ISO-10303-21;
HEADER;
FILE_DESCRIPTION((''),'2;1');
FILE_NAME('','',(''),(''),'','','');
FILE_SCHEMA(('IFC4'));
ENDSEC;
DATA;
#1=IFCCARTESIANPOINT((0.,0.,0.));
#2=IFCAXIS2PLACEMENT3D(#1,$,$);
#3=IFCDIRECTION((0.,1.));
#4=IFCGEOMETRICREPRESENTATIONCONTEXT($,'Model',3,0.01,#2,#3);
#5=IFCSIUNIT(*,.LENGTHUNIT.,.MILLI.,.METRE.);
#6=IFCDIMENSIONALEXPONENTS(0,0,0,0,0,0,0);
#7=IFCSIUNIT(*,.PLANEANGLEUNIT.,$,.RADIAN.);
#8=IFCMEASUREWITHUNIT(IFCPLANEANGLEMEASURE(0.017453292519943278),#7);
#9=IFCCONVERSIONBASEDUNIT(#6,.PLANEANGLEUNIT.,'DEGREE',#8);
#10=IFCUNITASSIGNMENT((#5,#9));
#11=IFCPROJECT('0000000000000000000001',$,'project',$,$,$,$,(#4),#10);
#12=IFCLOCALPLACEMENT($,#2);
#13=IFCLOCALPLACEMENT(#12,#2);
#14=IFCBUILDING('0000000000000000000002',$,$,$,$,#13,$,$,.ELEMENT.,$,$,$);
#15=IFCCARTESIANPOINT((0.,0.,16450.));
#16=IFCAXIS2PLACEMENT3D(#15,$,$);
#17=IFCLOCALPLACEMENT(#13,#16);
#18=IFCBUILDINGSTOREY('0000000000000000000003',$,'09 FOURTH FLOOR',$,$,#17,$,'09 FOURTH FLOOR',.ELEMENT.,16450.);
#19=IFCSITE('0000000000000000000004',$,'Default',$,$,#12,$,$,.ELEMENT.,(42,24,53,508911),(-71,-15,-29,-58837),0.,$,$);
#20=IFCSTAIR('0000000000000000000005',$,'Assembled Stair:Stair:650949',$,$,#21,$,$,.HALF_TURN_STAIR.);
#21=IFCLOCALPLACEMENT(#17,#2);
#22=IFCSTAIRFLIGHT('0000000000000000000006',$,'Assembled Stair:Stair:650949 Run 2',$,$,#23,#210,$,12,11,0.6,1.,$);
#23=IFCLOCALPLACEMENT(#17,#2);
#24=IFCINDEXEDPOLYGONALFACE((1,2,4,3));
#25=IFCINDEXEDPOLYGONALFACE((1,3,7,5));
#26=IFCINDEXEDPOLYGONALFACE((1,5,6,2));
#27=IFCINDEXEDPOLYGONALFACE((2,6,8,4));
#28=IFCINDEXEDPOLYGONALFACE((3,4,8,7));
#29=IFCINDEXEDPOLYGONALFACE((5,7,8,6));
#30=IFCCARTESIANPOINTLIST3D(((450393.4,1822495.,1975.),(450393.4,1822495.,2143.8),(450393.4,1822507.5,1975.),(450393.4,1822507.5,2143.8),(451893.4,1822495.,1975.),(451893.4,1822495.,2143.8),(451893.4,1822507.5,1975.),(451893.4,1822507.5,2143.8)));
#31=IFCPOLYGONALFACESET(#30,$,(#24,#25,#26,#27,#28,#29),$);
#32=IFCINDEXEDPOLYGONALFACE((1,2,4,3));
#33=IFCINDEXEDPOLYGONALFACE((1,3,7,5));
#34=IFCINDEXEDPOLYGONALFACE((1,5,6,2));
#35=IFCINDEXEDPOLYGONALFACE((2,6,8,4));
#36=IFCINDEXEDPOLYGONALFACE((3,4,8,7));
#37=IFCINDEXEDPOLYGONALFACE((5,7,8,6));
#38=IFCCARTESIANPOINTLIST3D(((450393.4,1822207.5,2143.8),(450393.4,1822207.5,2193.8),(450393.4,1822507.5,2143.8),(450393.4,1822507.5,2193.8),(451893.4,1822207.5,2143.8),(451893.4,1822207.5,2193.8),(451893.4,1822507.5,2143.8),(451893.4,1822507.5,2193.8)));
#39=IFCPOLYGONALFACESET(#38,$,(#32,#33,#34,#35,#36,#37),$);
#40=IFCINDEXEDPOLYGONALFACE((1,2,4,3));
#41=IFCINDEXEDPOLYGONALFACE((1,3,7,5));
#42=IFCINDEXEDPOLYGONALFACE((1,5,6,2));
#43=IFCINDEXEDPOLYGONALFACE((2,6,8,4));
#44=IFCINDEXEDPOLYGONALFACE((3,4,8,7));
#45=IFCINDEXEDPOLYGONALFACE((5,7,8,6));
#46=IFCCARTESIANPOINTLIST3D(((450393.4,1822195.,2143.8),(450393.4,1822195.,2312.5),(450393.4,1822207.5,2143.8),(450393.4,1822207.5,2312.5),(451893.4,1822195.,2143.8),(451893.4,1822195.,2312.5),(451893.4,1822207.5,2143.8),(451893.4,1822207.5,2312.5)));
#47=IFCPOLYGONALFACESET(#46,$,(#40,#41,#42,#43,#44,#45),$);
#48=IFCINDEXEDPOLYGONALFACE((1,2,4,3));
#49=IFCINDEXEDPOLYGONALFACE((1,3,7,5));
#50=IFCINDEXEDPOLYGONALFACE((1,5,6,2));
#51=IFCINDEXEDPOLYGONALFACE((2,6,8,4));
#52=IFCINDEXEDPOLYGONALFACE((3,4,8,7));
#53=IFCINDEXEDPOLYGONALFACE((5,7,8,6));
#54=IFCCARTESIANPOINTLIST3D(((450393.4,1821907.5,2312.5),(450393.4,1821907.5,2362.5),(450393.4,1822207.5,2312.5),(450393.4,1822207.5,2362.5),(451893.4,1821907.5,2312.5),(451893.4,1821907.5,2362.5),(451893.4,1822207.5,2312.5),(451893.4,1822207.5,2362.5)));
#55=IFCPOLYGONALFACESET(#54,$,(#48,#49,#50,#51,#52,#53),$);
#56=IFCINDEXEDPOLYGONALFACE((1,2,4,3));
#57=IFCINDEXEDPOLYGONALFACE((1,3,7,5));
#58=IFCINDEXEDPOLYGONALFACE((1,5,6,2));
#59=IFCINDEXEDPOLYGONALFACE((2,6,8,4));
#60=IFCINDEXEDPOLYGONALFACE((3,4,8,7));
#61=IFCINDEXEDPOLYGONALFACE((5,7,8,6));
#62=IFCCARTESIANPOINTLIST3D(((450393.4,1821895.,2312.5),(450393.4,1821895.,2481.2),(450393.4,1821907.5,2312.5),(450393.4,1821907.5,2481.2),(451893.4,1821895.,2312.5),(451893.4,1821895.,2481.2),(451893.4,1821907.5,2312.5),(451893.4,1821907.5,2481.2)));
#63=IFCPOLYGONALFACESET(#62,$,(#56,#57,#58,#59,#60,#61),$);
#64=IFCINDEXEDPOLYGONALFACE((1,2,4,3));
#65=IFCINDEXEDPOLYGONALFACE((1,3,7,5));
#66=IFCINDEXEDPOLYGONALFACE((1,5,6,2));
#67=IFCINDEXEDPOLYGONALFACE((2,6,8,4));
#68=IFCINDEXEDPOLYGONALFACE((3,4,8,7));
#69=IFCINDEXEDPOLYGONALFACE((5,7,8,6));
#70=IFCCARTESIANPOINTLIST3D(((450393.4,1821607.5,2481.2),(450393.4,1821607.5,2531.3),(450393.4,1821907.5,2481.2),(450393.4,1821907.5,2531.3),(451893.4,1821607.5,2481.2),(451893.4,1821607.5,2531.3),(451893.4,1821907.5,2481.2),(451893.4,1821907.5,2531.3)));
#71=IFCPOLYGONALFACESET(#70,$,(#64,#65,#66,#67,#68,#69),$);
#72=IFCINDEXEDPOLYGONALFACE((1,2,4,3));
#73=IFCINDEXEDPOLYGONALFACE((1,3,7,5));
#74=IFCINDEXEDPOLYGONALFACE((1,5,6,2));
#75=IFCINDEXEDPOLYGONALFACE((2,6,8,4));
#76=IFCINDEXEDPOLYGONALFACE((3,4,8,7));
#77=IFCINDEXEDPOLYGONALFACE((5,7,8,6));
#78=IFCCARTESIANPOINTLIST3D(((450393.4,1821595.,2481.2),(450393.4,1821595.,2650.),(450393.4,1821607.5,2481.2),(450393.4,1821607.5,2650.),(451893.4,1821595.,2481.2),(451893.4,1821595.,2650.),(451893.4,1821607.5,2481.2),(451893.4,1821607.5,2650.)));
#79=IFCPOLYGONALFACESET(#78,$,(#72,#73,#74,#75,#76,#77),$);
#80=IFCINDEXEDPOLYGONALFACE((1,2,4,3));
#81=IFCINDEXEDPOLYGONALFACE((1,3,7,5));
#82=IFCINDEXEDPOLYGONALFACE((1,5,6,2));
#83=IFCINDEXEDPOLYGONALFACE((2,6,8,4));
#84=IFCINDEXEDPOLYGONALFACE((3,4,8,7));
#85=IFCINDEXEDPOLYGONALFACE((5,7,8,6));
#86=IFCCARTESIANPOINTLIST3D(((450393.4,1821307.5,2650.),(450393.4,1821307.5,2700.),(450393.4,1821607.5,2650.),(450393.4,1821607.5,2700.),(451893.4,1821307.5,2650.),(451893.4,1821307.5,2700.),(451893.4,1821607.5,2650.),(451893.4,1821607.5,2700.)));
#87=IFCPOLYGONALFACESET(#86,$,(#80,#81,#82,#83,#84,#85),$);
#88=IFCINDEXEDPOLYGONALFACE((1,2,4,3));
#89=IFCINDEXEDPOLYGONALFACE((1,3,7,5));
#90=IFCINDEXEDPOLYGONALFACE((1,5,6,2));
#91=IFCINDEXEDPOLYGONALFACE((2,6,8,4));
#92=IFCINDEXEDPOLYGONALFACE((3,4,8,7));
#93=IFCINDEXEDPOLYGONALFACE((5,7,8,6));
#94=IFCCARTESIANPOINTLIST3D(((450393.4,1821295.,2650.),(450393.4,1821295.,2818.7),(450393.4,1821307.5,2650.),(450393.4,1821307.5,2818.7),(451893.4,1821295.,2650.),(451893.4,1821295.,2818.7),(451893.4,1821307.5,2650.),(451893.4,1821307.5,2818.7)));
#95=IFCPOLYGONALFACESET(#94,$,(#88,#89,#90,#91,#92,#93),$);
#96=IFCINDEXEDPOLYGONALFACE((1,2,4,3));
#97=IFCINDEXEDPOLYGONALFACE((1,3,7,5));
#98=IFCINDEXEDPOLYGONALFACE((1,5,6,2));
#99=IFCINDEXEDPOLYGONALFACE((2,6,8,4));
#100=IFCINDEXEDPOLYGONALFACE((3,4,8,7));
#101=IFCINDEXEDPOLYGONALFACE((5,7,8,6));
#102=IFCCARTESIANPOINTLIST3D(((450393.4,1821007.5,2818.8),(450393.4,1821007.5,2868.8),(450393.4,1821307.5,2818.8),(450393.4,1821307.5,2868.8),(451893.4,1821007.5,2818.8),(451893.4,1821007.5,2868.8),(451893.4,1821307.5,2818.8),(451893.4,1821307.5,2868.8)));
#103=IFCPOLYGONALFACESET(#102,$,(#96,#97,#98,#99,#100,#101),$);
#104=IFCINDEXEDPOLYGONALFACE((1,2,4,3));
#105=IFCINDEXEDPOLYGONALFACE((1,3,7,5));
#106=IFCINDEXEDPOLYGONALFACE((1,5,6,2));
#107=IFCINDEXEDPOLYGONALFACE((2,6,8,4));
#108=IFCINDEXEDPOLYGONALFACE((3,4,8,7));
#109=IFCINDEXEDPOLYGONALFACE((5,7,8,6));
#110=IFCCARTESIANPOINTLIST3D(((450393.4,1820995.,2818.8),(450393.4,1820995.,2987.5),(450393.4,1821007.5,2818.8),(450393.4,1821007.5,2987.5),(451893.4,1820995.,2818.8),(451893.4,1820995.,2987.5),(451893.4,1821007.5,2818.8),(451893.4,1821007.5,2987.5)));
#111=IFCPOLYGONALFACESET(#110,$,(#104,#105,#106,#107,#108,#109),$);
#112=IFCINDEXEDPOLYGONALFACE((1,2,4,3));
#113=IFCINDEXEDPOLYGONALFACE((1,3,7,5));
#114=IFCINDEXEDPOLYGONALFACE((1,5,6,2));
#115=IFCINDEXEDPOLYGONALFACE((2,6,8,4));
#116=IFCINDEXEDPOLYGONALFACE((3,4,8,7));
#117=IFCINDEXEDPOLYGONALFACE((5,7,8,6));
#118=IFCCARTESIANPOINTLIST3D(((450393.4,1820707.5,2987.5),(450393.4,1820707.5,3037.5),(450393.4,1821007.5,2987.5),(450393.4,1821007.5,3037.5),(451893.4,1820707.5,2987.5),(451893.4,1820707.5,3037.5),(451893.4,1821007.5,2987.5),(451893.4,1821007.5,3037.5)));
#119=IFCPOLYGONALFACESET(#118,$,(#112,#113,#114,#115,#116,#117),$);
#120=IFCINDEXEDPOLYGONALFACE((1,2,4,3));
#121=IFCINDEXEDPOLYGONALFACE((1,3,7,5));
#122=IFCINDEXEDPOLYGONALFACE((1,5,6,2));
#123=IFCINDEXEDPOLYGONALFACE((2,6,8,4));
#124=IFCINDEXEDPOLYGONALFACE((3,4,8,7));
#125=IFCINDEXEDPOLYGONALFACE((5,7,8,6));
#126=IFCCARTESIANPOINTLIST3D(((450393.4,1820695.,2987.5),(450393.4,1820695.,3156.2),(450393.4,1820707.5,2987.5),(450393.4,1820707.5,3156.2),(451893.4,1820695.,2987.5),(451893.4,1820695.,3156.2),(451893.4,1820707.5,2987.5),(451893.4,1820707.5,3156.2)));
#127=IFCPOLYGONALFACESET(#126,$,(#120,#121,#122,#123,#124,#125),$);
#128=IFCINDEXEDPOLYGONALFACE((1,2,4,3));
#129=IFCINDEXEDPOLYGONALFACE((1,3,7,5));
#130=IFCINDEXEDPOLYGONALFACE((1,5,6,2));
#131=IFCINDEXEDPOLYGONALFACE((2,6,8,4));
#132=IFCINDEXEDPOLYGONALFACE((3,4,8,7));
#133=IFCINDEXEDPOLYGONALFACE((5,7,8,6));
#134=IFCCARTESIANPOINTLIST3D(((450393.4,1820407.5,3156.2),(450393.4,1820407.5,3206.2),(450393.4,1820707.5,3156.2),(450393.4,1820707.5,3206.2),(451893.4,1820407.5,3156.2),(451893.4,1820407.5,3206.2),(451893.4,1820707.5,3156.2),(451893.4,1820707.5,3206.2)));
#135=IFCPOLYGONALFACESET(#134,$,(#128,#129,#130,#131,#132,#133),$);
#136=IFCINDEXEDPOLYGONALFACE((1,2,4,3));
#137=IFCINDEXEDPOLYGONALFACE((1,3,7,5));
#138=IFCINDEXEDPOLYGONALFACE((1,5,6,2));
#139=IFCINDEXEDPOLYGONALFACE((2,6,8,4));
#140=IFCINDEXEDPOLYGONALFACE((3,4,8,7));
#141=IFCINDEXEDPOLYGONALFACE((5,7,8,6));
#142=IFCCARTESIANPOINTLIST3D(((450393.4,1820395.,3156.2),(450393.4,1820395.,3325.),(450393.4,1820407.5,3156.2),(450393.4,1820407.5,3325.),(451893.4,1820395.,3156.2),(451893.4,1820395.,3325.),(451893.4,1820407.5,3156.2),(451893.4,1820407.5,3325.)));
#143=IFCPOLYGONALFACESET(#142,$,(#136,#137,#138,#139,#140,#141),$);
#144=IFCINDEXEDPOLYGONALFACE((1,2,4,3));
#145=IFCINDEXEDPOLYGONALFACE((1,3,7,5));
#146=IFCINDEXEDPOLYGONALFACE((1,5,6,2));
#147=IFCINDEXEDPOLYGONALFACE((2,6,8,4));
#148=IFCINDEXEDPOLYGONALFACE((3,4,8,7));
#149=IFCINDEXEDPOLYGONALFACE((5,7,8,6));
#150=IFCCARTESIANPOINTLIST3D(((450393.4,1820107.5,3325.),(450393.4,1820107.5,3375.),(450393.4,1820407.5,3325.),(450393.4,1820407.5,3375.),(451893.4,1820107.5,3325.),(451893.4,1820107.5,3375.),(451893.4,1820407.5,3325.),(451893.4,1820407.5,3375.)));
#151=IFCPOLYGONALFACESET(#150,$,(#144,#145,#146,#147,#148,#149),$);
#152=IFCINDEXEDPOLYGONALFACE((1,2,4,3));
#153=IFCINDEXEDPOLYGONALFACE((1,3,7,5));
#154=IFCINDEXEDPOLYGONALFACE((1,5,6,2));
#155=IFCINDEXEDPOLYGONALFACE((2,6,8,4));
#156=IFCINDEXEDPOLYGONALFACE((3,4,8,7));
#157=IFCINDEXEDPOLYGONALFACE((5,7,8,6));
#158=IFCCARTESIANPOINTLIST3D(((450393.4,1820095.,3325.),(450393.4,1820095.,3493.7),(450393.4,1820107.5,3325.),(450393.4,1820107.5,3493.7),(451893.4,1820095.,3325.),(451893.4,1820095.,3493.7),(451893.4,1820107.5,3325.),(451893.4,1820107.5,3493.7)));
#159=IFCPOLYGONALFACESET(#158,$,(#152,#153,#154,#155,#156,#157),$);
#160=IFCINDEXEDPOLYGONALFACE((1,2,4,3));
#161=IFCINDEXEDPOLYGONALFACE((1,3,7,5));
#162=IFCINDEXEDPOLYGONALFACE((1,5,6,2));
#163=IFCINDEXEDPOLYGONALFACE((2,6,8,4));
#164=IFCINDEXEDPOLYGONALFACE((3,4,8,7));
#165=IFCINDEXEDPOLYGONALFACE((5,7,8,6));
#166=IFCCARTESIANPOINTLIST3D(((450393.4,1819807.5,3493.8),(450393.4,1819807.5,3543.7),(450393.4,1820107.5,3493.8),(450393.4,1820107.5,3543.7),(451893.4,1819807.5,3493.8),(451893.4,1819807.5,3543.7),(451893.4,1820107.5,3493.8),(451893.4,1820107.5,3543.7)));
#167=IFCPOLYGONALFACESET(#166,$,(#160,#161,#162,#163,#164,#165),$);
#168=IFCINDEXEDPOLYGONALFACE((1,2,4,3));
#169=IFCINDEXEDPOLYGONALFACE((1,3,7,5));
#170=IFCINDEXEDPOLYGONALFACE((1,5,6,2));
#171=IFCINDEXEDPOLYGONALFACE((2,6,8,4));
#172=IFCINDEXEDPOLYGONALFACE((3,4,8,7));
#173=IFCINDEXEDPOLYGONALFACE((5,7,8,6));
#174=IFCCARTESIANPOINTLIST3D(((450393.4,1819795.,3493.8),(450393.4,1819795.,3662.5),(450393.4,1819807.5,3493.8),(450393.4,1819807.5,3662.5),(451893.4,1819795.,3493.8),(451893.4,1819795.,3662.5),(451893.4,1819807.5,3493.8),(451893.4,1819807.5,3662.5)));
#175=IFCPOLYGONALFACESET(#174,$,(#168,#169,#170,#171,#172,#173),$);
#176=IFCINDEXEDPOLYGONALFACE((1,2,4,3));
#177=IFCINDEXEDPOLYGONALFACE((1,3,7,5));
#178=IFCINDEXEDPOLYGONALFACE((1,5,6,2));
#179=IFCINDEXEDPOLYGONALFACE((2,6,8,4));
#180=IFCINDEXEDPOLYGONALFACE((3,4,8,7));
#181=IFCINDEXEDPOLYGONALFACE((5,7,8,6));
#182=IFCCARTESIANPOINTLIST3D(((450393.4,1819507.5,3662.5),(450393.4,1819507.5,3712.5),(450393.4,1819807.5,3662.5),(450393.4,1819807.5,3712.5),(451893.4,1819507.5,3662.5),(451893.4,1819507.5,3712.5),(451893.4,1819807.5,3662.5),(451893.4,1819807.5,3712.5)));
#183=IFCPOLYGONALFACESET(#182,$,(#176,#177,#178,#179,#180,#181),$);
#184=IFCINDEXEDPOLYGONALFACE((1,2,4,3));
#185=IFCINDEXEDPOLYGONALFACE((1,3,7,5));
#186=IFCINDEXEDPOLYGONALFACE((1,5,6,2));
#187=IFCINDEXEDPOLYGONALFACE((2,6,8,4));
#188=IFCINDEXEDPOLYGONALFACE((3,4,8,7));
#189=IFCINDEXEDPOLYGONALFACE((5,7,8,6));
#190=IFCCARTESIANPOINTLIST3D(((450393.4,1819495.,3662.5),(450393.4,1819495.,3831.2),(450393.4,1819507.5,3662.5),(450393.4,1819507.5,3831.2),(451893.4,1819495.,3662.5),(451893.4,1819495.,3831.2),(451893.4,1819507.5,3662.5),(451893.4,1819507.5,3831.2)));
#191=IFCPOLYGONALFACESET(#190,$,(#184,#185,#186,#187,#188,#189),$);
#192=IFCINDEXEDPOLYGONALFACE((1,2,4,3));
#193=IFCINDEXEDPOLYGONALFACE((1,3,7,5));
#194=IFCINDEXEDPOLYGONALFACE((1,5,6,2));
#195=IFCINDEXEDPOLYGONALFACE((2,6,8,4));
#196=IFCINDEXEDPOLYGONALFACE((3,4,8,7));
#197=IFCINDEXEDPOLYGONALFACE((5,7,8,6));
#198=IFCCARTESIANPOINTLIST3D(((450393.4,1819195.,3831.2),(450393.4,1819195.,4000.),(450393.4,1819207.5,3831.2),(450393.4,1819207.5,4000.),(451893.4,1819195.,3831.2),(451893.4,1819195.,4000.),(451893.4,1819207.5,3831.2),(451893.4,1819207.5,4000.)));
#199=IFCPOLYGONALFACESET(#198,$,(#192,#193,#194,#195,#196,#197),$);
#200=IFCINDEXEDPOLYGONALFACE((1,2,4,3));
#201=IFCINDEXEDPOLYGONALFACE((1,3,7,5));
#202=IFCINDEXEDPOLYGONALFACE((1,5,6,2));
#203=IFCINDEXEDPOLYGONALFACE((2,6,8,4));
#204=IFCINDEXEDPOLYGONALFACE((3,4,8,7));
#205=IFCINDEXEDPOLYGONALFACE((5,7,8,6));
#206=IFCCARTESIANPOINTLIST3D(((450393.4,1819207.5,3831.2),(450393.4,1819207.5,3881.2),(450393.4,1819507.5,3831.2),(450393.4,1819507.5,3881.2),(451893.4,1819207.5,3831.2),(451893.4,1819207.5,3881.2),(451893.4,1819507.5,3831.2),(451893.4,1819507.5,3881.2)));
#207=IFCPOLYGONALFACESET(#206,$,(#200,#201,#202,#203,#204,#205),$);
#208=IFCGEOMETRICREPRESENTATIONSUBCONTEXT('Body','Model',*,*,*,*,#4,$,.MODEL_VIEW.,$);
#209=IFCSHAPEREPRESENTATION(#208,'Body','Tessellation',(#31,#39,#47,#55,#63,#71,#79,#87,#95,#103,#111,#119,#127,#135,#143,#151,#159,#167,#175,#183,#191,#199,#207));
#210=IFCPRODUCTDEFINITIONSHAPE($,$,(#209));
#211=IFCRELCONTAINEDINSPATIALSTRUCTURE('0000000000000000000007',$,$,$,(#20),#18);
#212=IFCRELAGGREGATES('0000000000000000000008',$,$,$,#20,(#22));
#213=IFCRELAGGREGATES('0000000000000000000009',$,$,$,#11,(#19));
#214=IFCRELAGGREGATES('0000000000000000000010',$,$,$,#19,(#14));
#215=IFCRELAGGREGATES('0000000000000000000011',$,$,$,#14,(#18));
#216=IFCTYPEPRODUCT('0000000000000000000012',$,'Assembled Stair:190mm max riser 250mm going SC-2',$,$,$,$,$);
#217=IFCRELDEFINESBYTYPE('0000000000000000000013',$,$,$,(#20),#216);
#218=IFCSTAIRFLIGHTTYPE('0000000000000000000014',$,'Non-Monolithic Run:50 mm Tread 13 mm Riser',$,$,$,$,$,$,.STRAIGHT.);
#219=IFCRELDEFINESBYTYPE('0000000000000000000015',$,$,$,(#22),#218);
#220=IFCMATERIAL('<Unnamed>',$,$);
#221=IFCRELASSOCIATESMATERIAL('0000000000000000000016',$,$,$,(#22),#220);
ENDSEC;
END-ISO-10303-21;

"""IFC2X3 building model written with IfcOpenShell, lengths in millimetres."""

from ifc_helpers import new_model, entity, si_unit, converted_unit, direction, frame, frame_2d, origin, origin_2d_with_axis, place, context, subcontext, project, spatial, rectangle, extrude, material, type_object, element, aggregate, save


model = new_model("IFC2X3")

# Units and contexts
model_context = context("Model", 3, precision=0.01, world=origin(), true_north=direction((0.0, 1.0)))
body_context = subcontext(model_context, "Body", "Model", "MODEL_VIEW")
ifc_project = project(units=[si_unit("LENGTHUNIT", "METRE", prefix="MILLI"), converted_unit("PLANEANGLEUNIT", "DEGREE", entity("IfcPlaneAngleMeasure", 0.017453292519943278), si_unit("PLANEANGLEUNIT", "RADIAN"), dimensions=[0, 0, 0, 0, 0, 0, 0])], contexts=[model_context])

# Site, building, storey
site_placement = place(None, origin())
site = spatial("IfcSite", under=ifc_project, at=site_placement, Name="Default", CompositionType="ELEMENT", RefLatitude=(42, 24, 53, 508911), RefLongitude=(-71, -15, -29, -58837), RefElevation=0.0)
building_placement = place(site_placement, origin())
building = spatial("IfcBuilding", under=site, at=building_placement, CompositionType="ELEMENT")
storey_placement = place(building_placement, frame((0.0, 0.0, 16450.0)))
storey = spatial("IfcBuildingStorey", under=building, at=storey_placement, Name="09 FOURTH FLOOR", LongName="09 FOURTH FLOOR", CompositionType="ELEMENT", Elevation=16450.0)

# Stair
ifc_material_1 = material(Name="<Unnamed>")
type_product_1 = type_object("IfcTypeProduct", Name="Assembled Stair:190mm max riser 250mm going SC-2")
stair_1_placement = place(storey_placement, origin())
stair_1 = element("IfcStair", 1, at=stair_1_placement, inside=storey, type_object=type_product_1, Name="Assembled Stair:Stair:650949", ShapeType="HALF_TURN_STAIR")

# Stair flight
stair_flight_type = type_object("IfcStairFlightType", Name="Non-Monolithic Run:50 mm Tread 13 mm Riser", PredefinedType="STRAIGHT")
stair_flight_1_placement = place(stair_1_placement, origin())
stair_flight_1 = element("IfcStairFlight", 2, at=stair_flight_1_placement, type_object=stair_flight_type, material=ifc_material_1, Name="Assembled Stair:Stair:650949 Run 2", NumberOfRiser=12, NumberOfTreads=11, RiserHeight=0.6, TreadLength=1.0, context=body_context, shape_type="SweptSolid", body=[
    extrude(rectangle(XDim=1500.0, YDim=12.5, at=origin_2d_with_axis()), frame((451143.4, 1822501.3, 1975.0)), (0.0, 0.0, 1.0), 168.8),
    extrude(rectangle(XDim=300.0, YDim=1500.0, at=frame_2d((0.0, 0.0), x_axis=(1.0, 0.0))), frame((451143.4, 1822357.5, 2143.8), z_axis=(0.0, 0.0, 1.0), x_axis=(0.0, 1.0, 0.0)), (0.0, 0.0, 1.0), 50.0),
    extrude(rectangle(XDim=1500.0, YDim=12.5, at=origin_2d_with_axis()), frame((451143.4, 1822201.3, 2143.8)), (0.0, 0.0, 1.0), 168.8),
    extrude(rectangle(XDim=300.0, YDim=1500.0, at=origin_2d_with_axis()), frame((451143.4, 1822057.5, 2312.5), z_axis=(0.0, 0.0, 1.0), x_axis=(0.0, 1.0, 0.0)), (0.0, 0.0, 1.0), 50.0),
    extrude(rectangle(XDim=1500.0, YDim=12.5, at=origin_2d_with_axis()), frame((451143.4, 1821901.3, 2312.5)), (0.0, 0.0, 1.0), 168.8),
    extrude(rectangle(XDim=300.0, YDim=1500.0, at=origin_2d_with_axis()), frame((451143.4, 1821757.5, 2481.3), z_axis=(0.0, 0.0, 1.0), x_axis=(0.0, 1.0, 0.0)), (0.0, 0.0, 1.0), 50.0),
    extrude(rectangle(XDim=1500.0, YDim=12.5, at=origin_2d_with_axis()), frame((451143.4, 1821601.3, 2481.3)), (0.0, 0.0, 1.0), 168.8),
    extrude(rectangle(XDim=300.0, YDim=1500.0, at=origin_2d_with_axis()), frame((451143.4, 1821457.5, 2650.0), z_axis=(0.0, 0.0, 1.0), x_axis=(0.0, 1.0, 0.0)), (0.0, 0.0, 1.0), 50.0),
    extrude(rectangle(XDim=1500.0, YDim=12.5, at=origin_2d_with_axis()), frame((451143.4, 1821301.3, 2650.0)), (0.0, 0.0, 1.0), 168.8),
    extrude(rectangle(XDim=300.0, YDim=1500.0, at=origin_2d_with_axis()), frame((451143.4, 1821157.5, 2818.8), z_axis=(0.0, 0.0, 1.0), x_axis=(0.0, 1.0, 0.0)), (0.0, 0.0, 1.0), 50.0),
    extrude(rectangle(XDim=1500.0, YDim=12.5, at=origin_2d_with_axis()), frame((451143.4, 1821001.3, 2818.8)), (0.0, 0.0, 1.0), 168.8),
    extrude(rectangle(XDim=300.0, YDim=1500.0, at=origin_2d_with_axis()), frame((451143.4, 1820857.5, 2987.5), z_axis=(0.0, 0.0, 1.0), x_axis=(0.0, 1.0, 0.0)), (0.0, 0.0, 1.0), 50.0),
    extrude(rectangle(XDim=1500.0, YDim=12.5, at=origin_2d_with_axis()), frame((451143.4, 1820701.3, 2987.5)), (0.0, 0.0, 1.0), 168.8),
    extrude(rectangle(XDim=300.0, YDim=1500.0, at=origin_2d_with_axis()), frame((451143.4, 1820557.5, 3156.2), z_axis=(0.0, 0.0, 1.0), x_axis=(0.0, 1.0, 0.0)), (0.0, 0.0, 1.0), 50.0),
    extrude(rectangle(XDim=1500.0, YDim=12.5, at=origin_2d_with_axis()), frame((451143.4, 1820401.3, 3156.2)), (0.0, 0.0, 1.0), 168.8),
    extrude(rectangle(XDim=300.0, YDim=1500.0, at=origin_2d_with_axis()), frame((451143.4, 1820257.5, 3325.0), z_axis=(0.0, 0.0, 1.0), x_axis=(0.0, 1.0, 0.0)), (0.0, 0.0, 1.0), 50.0),
    extrude(rectangle(XDim=1500.0, YDim=12.5, at=origin_2d_with_axis()), frame((451143.4, 1820101.3, 3325.0)), (0.0, 0.0, 1.0), 168.8),
    extrude(rectangle(XDim=300.0, YDim=1500.0, at=origin_2d_with_axis()), frame((451143.4, 1819957.5, 3493.8), z_axis=(0.0, 0.0, 1.0), x_axis=(0.0, 1.0, 0.0)), (0.0, 0.0, 1.0), 50.0),
    extrude(rectangle(XDim=1500.0, YDim=12.5, at=origin_2d_with_axis()), frame((451143.4, 1819801.3, 3493.8)), (0.0, 0.0, 1.0), 168.8),
    extrude(rectangle(XDim=300.0, YDim=1500.0, at=origin_2d_with_axis()), frame((451143.4, 1819657.5, 3662.5), z_axis=(0.0, 0.0, 1.0), x_axis=(0.0, 1.0, 0.0)), (0.0, 0.0, 1.0), 50.0),
    extrude(rectangle(XDim=1500.0, YDim=12.5, at=origin_2d_with_axis()), frame((451143.4, 1819501.3, 3662.5)), (0.0, 0.0, 1.0), 168.8),
    extrude(rectangle(XDim=1500.0, YDim=12.5, at=origin_2d_with_axis()), frame((451143.4, 1819201.3, 3831.3)), (0.0, 0.0, 1.0), 168.8),
    extrude(rectangle(XDim=300.0, YDim=1500.0, at=origin_2d_with_axis()), frame((451143.4, 1819357.5, 3831.3), z_axis=(0.0, 0.0, 1.0), x_axis=(0.0, 1.0, 0.0)), (0.0, 0.0, 1.0), 50.0),
])

aggregate(stair_1, [stair_flight_1])

save(model, "model.ifc")
